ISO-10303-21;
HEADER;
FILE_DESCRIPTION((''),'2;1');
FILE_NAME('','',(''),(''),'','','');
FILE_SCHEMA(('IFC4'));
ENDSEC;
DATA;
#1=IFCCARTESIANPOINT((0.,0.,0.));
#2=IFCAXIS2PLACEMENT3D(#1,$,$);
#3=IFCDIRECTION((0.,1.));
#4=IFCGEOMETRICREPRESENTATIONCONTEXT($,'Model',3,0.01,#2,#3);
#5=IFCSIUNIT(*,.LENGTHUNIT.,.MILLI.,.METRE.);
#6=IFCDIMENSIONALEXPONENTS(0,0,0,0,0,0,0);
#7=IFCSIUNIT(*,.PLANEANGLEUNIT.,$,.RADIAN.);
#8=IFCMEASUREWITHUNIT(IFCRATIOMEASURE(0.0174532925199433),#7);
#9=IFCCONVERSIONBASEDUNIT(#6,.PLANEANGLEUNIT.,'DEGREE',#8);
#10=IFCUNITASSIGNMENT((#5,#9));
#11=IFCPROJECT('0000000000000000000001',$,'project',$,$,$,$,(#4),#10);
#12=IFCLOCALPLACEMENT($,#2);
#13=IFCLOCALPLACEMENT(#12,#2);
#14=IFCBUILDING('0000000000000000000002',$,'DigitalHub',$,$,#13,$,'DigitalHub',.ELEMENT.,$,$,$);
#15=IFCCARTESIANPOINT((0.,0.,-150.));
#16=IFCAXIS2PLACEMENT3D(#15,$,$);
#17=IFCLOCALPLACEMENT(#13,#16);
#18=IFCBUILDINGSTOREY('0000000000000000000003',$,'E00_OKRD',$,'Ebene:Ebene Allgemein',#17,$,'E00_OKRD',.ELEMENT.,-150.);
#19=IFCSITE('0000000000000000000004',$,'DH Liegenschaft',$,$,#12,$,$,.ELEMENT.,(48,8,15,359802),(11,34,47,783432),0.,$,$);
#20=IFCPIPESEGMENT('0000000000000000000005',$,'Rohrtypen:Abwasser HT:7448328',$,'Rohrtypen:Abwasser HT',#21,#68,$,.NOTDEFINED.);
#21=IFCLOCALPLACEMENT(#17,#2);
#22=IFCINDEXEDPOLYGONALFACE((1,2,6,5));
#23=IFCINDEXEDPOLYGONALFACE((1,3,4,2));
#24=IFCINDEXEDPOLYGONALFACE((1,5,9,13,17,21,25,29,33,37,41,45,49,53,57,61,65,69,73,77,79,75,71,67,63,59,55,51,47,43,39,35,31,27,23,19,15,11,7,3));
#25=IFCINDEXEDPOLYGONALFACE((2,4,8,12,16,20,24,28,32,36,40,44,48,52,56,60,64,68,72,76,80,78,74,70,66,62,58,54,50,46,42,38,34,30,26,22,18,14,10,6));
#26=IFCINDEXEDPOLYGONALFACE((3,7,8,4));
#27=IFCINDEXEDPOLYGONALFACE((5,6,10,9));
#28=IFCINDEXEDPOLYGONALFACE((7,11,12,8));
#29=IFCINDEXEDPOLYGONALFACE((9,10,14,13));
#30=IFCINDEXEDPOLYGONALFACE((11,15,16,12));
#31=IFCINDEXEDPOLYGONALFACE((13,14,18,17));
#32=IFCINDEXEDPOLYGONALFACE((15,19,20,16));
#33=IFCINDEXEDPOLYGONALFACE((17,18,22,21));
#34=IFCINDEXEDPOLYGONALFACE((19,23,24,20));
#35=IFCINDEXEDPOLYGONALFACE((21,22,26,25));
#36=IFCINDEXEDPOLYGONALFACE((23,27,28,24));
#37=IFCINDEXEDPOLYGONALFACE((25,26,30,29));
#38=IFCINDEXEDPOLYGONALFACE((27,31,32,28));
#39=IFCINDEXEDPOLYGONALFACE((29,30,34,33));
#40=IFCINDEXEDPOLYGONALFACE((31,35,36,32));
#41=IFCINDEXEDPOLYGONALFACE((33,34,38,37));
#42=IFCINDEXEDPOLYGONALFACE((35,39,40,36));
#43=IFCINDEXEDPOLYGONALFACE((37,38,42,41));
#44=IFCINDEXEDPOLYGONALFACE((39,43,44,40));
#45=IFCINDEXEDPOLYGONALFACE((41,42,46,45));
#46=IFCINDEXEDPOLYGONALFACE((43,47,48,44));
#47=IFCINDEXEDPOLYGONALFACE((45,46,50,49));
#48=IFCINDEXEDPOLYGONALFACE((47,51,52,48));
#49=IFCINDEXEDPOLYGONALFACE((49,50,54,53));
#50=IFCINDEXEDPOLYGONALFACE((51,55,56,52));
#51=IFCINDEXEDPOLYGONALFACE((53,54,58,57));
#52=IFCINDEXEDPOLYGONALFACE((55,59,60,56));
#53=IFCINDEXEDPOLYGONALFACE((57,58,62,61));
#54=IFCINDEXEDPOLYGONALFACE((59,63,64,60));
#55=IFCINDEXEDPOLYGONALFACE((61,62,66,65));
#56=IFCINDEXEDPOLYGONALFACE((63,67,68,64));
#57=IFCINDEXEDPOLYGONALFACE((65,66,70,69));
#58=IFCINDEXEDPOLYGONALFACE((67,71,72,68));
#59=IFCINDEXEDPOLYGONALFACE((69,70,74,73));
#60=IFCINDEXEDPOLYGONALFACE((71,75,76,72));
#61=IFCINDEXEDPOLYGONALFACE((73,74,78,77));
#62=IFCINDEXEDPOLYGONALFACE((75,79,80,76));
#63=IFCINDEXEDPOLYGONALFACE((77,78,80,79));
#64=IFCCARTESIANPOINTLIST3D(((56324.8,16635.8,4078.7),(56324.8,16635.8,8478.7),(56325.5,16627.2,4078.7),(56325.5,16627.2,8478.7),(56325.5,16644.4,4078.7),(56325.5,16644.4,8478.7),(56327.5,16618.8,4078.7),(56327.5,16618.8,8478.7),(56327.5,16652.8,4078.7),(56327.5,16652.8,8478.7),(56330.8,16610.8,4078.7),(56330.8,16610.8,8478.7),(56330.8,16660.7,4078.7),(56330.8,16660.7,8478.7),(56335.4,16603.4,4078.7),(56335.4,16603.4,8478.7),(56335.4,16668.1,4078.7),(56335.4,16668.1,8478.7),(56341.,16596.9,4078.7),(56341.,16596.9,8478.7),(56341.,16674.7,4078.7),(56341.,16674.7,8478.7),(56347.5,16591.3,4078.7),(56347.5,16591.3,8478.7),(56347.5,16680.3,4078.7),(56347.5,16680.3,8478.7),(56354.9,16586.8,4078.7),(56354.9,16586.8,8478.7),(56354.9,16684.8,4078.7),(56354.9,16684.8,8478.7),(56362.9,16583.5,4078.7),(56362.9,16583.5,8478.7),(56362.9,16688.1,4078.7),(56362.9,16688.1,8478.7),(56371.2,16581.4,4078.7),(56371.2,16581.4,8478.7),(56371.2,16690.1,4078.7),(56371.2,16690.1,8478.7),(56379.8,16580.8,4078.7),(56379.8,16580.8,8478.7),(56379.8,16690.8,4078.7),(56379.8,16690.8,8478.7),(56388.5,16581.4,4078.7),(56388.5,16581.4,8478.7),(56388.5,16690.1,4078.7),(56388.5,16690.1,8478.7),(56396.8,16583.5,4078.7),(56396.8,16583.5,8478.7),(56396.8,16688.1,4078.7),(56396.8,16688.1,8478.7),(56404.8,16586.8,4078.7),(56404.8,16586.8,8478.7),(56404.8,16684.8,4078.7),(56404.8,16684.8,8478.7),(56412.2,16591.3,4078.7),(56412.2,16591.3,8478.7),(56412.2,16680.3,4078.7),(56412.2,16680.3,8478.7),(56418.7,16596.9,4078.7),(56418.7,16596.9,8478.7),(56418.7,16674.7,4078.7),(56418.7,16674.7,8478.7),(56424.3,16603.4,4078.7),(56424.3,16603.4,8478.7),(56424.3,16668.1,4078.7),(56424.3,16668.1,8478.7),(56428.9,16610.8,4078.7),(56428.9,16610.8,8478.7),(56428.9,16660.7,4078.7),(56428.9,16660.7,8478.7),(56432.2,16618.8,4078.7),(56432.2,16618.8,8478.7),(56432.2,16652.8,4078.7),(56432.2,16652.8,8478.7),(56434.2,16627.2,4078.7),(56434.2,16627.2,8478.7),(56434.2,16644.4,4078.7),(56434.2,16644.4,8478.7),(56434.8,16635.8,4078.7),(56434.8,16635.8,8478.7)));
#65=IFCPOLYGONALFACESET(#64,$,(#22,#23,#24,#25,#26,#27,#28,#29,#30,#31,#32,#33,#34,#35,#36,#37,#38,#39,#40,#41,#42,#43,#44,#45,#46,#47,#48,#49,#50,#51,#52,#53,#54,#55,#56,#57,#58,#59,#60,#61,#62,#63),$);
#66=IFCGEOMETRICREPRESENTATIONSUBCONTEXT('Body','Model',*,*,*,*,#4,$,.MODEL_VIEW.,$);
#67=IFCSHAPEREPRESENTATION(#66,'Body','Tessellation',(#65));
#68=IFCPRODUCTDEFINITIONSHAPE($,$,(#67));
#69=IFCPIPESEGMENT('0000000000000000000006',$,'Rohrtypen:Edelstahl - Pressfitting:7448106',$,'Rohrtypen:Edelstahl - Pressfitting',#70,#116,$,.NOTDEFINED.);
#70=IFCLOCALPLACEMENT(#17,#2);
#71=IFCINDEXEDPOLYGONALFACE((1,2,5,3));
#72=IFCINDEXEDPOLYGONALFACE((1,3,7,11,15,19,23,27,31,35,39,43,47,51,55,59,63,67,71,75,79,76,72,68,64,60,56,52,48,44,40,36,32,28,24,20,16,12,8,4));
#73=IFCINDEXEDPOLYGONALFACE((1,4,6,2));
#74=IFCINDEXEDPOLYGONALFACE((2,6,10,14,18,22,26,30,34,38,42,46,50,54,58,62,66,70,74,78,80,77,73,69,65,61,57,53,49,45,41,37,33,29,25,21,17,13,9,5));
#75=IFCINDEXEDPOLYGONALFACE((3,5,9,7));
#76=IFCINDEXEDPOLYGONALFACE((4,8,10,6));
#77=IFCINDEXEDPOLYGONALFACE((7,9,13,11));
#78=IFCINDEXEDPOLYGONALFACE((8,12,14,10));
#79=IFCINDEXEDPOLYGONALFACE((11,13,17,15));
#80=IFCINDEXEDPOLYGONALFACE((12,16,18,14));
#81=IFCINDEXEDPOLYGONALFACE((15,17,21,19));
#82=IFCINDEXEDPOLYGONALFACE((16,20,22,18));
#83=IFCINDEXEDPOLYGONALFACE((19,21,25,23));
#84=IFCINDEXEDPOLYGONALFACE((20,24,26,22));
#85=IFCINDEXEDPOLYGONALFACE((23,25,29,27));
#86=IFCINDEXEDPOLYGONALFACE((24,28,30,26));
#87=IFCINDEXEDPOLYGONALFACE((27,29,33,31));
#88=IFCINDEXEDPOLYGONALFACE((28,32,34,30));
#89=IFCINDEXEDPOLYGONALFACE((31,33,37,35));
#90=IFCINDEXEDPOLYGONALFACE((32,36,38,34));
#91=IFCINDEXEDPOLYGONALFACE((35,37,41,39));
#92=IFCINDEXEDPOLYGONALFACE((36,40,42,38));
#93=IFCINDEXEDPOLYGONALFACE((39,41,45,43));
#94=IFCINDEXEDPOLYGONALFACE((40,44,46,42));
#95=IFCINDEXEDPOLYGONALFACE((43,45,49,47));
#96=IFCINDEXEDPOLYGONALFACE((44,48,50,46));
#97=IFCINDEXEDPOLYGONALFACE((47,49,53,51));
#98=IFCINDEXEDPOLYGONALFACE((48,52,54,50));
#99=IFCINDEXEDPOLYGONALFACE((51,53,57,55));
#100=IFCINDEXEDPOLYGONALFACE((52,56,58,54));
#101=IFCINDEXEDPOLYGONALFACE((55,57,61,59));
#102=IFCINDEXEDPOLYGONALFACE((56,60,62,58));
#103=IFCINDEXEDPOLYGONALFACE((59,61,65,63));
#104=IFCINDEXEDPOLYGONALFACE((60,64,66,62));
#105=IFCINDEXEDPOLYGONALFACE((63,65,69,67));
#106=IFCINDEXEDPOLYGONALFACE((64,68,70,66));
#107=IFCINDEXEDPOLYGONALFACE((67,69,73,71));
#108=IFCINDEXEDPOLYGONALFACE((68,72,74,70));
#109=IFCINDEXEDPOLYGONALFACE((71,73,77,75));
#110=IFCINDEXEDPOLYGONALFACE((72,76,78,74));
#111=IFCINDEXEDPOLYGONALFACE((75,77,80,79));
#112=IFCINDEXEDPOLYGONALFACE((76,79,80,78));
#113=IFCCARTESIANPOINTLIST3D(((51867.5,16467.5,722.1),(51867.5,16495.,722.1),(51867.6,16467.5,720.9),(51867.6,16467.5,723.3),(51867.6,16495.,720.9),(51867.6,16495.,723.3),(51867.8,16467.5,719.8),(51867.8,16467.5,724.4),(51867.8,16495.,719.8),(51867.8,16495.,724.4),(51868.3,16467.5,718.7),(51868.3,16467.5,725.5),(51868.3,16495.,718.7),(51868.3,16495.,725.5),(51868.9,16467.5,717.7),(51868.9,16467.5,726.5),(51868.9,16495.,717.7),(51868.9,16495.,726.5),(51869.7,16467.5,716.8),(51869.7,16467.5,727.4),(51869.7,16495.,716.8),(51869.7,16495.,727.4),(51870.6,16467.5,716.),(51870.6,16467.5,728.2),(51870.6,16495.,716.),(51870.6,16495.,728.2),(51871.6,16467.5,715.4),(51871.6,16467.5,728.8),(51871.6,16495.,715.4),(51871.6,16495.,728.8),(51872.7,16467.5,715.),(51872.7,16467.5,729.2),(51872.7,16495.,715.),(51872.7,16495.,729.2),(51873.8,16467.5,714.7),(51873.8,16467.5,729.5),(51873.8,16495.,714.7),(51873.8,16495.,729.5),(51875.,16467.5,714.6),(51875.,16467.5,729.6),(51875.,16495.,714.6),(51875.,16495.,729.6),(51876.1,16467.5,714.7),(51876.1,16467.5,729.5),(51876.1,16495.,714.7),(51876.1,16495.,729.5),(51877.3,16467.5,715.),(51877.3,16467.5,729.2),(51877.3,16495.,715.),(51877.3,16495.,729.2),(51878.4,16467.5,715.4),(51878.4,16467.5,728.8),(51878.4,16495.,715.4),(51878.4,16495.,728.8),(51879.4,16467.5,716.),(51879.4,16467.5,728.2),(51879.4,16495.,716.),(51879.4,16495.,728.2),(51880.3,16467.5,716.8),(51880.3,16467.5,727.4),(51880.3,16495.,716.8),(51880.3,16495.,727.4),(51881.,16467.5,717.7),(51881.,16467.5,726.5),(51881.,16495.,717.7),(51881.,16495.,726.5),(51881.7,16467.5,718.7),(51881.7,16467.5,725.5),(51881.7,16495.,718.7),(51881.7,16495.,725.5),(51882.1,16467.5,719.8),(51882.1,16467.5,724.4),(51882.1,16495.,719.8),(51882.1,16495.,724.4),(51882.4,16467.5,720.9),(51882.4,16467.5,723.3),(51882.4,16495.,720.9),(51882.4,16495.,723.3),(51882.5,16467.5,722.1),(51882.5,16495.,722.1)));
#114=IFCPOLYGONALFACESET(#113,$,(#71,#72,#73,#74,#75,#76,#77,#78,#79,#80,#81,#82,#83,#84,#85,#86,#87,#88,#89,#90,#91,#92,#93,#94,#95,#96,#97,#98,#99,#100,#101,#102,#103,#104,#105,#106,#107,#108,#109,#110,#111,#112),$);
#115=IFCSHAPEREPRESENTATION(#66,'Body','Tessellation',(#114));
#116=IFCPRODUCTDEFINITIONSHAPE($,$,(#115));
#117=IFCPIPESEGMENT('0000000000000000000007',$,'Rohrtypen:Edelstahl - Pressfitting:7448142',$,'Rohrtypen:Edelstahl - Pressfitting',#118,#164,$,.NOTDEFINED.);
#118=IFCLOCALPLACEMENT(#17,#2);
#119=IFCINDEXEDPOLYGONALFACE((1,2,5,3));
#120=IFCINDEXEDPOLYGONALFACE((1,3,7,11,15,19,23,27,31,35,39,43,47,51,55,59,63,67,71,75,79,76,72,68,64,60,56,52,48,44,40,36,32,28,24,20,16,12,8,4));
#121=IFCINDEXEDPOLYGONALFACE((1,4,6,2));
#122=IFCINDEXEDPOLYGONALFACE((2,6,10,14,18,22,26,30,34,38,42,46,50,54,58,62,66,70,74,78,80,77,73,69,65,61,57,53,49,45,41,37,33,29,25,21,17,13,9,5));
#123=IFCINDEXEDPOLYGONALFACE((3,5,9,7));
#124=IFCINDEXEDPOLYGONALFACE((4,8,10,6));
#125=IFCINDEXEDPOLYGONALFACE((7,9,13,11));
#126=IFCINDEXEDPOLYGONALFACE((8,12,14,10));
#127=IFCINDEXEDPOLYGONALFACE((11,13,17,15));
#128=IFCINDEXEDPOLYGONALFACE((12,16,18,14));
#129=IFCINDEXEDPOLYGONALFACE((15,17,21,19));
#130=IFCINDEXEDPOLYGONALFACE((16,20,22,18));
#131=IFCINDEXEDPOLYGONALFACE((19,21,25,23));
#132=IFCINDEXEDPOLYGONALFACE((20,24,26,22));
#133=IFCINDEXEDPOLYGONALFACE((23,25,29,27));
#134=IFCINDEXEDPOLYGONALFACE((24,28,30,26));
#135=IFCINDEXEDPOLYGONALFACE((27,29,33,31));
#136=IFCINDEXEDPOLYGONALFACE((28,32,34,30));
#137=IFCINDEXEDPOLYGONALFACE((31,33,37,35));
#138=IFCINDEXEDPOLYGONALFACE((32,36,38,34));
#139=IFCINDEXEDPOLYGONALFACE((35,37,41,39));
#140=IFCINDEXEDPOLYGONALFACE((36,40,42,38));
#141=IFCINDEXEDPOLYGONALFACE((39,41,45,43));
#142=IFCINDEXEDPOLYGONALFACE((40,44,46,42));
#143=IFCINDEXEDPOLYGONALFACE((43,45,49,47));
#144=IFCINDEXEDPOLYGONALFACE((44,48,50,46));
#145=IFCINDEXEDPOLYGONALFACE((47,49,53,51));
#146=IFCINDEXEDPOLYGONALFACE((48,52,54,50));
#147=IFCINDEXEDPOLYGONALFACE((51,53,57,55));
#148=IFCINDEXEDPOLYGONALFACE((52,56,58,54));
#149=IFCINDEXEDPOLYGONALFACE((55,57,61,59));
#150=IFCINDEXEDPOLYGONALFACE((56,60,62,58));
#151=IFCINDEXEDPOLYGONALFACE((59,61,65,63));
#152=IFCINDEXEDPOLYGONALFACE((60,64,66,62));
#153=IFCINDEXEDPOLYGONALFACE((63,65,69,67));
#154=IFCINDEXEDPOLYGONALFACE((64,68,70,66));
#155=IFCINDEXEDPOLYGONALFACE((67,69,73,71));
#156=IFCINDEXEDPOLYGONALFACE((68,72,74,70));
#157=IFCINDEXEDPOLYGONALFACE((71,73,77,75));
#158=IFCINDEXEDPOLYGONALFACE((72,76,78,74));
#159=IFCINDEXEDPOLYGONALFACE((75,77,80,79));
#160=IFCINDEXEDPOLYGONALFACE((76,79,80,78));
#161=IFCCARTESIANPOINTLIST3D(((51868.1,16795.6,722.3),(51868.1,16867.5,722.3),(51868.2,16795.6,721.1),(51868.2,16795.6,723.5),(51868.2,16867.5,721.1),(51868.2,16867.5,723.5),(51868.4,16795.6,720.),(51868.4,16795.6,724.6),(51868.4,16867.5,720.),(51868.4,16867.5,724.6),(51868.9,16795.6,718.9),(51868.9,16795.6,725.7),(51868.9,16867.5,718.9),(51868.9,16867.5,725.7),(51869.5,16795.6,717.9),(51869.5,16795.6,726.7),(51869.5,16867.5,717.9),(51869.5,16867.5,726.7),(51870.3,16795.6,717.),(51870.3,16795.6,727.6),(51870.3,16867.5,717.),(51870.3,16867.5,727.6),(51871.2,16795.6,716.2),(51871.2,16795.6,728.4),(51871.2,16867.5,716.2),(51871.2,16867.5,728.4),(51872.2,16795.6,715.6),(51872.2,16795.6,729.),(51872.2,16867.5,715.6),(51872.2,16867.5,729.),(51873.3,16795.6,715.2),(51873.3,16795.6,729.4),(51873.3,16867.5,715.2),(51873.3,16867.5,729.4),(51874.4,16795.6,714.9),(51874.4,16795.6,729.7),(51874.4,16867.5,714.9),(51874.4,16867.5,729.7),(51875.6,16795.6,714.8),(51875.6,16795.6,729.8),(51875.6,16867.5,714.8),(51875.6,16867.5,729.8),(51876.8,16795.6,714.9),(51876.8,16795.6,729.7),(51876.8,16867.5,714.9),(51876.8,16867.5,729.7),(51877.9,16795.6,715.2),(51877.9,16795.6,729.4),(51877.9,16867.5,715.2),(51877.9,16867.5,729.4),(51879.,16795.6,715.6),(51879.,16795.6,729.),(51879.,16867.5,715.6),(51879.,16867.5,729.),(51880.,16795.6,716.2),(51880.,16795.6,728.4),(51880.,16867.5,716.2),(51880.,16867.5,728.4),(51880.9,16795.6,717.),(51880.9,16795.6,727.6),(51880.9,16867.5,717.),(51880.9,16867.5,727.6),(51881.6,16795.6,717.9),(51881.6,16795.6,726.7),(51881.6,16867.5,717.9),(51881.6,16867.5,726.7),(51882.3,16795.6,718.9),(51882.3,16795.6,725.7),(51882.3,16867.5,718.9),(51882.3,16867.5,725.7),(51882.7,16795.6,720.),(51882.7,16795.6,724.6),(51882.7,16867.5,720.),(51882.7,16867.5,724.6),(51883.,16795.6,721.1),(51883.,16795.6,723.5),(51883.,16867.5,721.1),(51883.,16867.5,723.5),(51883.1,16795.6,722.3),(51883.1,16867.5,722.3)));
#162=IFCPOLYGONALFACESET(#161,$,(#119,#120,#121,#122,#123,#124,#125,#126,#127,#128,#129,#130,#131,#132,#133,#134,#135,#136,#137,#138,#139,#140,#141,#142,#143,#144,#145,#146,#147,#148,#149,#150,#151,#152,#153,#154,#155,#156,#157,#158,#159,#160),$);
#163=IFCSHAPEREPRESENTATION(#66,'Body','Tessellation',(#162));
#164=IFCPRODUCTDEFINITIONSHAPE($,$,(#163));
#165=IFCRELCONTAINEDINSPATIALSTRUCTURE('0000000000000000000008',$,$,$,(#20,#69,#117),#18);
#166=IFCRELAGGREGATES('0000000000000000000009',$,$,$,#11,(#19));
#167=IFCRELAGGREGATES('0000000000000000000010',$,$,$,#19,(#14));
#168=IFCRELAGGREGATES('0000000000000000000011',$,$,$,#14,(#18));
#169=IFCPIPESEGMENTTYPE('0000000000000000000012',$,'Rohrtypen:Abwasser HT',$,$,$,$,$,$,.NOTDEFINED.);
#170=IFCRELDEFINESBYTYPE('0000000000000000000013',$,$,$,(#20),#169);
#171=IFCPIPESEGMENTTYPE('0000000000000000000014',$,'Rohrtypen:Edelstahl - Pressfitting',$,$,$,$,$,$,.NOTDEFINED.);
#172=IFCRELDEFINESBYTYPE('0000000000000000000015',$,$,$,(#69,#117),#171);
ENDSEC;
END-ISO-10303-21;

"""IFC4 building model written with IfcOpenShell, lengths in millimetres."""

from ifc_helpers import new_model, entity, si_unit, converted_unit, direction, frame, origin, place, context, subcontext, project, spatial, indexed_curve, outline, extrude, type_object, element, save


model = new_model("IFC4")

# Units and contexts
model_context = context("Model", 3, precision=0.01, world=origin(), true_north=direction((0.0, 1.0)))
body_context = subcontext(model_context, "Body", "Model", "MODEL_VIEW")
ifc_project = project(units=[si_unit("LENGTHUNIT", "METRE", prefix="MILLI"), converted_unit("PLANEANGLEUNIT", "DEGREE", entity("IfcRatioMeasure", 0.0174532925199433), si_unit("PLANEANGLEUNIT", "RADIAN"), dimensions=[0, 0, 0, 0, 0, 0, 0])], contexts=[model_context])

# Site, building, storey
site_placement = place(None, origin())
site = spatial("IfcSite", under=ifc_project, at=site_placement, Name="DH Liegenschaft", CompositionType="ELEMENT", RefLatitude=(48, 8, 15, 359802), RefLongitude=(11, 34, 47, 783432), RefElevation=0.0)
building_placement = place(site_placement, origin())
building = spatial("IfcBuilding", under=site, at=building_placement, Name="DigitalHub", LongName="DigitalHub", CompositionType="ELEMENT")
storey_placement = place(building_placement, frame((0.0, 0.0, -150.0)))
storey = spatial("IfcBuildingStorey", under=building, at=storey_placement, Name="E00_OKRD", ObjectType="Ebene:Ebene Allgemein", LongName="E00_OKRD", CompositionType="ELEMENT", Elevation=-150.0)

# Pipe segments
pipe_segment_type_1 = type_object("IfcPipeSegmentType", Name="Rohrtypen:Abwasser HT", PredefinedType="NOTDEFINED")
pipe_segment_1_placement = place(storey_placement, frame((56323.3, 16579.2, 4078.7)))
element("IfcPipeSegment", 1, at=pipe_segment_1_placement, inside=storey, type_object=pipe_segment_type_1, Name="Rohrtypen:Abwasser HT:7448328", ObjectType="Rohrtypen:Abwasser HT", PredefinedType="NOTDEFINED", context=body_context, shape_type="SweptSolid", body=[
    extrude(outline(indexed_curve([(55.0, 0.0), (54.3, 8.6), (52.3, 17.0), (49.0, 25.0), (44.5, 32.3), (38.9, 38.9), (32.3, 44.5), (25.0, 49.0), (17.0, 52.3), (8.6, 54.3), (0.0, 55.0), (-8.6, 54.3), (-17.0, 52.3), (-25.0, 49.0), (-32.3, 44.5), (-38.9, 38.9), (-44.5, 32.3), (-49.0, 25.0), (-52.3, 17.0), (-54.3, 8.6), (-55.0, 0.0), (-54.3, -8.6), (-52.3, -17.0), (-49.0, -25.0), (-44.5, -32.3), (-38.9, -38.9), (-32.3, -44.5), (-25.0, -49.0), (-17.0, -52.3), (-8.6, -54.3), (0.0, -55.0), (8.6, -54.3), (17.0, -52.3), (25.0, -49.0), (32.3, -44.5), (38.9, -38.9), (44.5, -32.3), (49.0, -25.0), (52.3, -17.0), (54.3, -8.6), (55.0, 0.0)], self_intersect=False)), frame((56.6, 56.6, 0.0), z_axis=(0.0, 0.0, 1.0), x_axis=(-1.0, 0.0, 0.0)), (0.0, 0.0, 1.0), 4400.0),
])
pipe_segment_type_2 = type_object("IfcPipeSegmentType", Name="Rohrtypen:Edelstahl - Pressfitting", PredefinedType="NOTDEFINED")
pipe_segment_2_placement = place(storey_placement, frame((51865.9, 16467.5, 713.0)))
element("IfcPipeSegment", 2, at=pipe_segment_2_placement, inside=storey, type_object=pipe_segment_type_2, Name="Rohrtypen:Edelstahl - Pressfitting:7448106", ObjectType="Rohrtypen:Edelstahl - Pressfitting", PredefinedType="NOTDEFINED", context=body_context, shape_type="SweptSolid", body=[
    extrude(outline(indexed_curve([(7.5, 0.0), (7.4, 1.2), (7.1, 2.3), (6.7, 3.4), (6.1, 4.4), (5.3, 5.3), (4.4, 6.1), (3.4, 6.7), (2.3, 7.1), (1.2, 7.4), (0.0, 7.5), (-1.2, 7.4), (-2.3, 7.1), (-3.4, 6.7), (-4.4, 6.1), (-5.3, 5.3), (-6.1, 4.4), (-6.7, 3.4), (-7.1, 2.3), (-7.4, 1.2), (-7.5, 0.0), (-7.4, -1.2), (-7.1, -2.3), (-6.7, -3.4), (-6.1, -4.4), (-5.3, -5.3), (-4.4, -6.1), (-3.4, -6.7), (-2.3, -7.1), (-1.2, -7.4), (0.0, -7.5), (1.2, -7.4), (2.3, -7.1), (3.4, -6.7), (4.4, -6.1), (5.3, -5.3), (6.1, -4.4), (6.7, -3.4), (7.1, -2.3), (7.4, -1.2), (7.5, 0.0)], self_intersect=False)), frame((9.1, 0.0, 9.1), z_axis=(0.0, 1.0, 0.0), x_axis=(1.0, 0.0, 0.0)), (0.0, 0.0, 1.0), 27.4),
])
pipe_segment_3_placement = place(storey_placement, frame((51866.5, 16795.6, 713.2)))
element("IfcPipeSegment", 3, at=pipe_segment_3_placement, inside=storey, type_object=pipe_segment_type_2, Name="Rohrtypen:Edelstahl - Pressfitting:7448142", ObjectType="Rohrtypen:Edelstahl - Pressfitting", PredefinedType="NOTDEFINED", context=body_context, shape_type="SweptSolid", body=[
    extrude(outline(indexed_curve([(7.5, 0.0), (7.4, 1.2), (7.1, 2.3), (6.7, 3.4), (6.1, 4.4), (5.3, 5.3), (4.4, 6.1), (3.4, 6.7), (2.3, 7.1), (1.2, 7.4), (0.0, 7.5), (-1.2, 7.4), (-2.3, 7.1), (-3.4, 6.7), (-4.4, 6.1), (-5.3, 5.3), (-6.1, 4.4), (-6.7, 3.4), (-7.1, 2.3), (-7.4, 1.2), (-7.5, 0.0), (-7.4, -1.2), (-7.1, -2.3), (-6.7, -3.4), (-6.1, -4.4), (-5.3, -5.3), (-4.4, -6.1), (-3.4, -6.7), (-2.3, -7.1), (-1.2, -7.4), (0.0, -7.5), (1.2, -7.4), (2.3, -7.1), (3.4, -6.7), (4.4, -6.1), (5.3, -5.3), (6.1, -4.4), (6.7, -3.4), (7.1, -2.3), (7.4, -1.2), (7.5, 0.0)], self_intersect=False)), frame((9.1, 0.0, 9.1), z_axis=(0.0, 1.0, 0.0), x_axis=(-1.0, 0.0, 0.0)), (0.0, 0.0, 1.0), 71.9),
])

save(model, "model.ifc")
